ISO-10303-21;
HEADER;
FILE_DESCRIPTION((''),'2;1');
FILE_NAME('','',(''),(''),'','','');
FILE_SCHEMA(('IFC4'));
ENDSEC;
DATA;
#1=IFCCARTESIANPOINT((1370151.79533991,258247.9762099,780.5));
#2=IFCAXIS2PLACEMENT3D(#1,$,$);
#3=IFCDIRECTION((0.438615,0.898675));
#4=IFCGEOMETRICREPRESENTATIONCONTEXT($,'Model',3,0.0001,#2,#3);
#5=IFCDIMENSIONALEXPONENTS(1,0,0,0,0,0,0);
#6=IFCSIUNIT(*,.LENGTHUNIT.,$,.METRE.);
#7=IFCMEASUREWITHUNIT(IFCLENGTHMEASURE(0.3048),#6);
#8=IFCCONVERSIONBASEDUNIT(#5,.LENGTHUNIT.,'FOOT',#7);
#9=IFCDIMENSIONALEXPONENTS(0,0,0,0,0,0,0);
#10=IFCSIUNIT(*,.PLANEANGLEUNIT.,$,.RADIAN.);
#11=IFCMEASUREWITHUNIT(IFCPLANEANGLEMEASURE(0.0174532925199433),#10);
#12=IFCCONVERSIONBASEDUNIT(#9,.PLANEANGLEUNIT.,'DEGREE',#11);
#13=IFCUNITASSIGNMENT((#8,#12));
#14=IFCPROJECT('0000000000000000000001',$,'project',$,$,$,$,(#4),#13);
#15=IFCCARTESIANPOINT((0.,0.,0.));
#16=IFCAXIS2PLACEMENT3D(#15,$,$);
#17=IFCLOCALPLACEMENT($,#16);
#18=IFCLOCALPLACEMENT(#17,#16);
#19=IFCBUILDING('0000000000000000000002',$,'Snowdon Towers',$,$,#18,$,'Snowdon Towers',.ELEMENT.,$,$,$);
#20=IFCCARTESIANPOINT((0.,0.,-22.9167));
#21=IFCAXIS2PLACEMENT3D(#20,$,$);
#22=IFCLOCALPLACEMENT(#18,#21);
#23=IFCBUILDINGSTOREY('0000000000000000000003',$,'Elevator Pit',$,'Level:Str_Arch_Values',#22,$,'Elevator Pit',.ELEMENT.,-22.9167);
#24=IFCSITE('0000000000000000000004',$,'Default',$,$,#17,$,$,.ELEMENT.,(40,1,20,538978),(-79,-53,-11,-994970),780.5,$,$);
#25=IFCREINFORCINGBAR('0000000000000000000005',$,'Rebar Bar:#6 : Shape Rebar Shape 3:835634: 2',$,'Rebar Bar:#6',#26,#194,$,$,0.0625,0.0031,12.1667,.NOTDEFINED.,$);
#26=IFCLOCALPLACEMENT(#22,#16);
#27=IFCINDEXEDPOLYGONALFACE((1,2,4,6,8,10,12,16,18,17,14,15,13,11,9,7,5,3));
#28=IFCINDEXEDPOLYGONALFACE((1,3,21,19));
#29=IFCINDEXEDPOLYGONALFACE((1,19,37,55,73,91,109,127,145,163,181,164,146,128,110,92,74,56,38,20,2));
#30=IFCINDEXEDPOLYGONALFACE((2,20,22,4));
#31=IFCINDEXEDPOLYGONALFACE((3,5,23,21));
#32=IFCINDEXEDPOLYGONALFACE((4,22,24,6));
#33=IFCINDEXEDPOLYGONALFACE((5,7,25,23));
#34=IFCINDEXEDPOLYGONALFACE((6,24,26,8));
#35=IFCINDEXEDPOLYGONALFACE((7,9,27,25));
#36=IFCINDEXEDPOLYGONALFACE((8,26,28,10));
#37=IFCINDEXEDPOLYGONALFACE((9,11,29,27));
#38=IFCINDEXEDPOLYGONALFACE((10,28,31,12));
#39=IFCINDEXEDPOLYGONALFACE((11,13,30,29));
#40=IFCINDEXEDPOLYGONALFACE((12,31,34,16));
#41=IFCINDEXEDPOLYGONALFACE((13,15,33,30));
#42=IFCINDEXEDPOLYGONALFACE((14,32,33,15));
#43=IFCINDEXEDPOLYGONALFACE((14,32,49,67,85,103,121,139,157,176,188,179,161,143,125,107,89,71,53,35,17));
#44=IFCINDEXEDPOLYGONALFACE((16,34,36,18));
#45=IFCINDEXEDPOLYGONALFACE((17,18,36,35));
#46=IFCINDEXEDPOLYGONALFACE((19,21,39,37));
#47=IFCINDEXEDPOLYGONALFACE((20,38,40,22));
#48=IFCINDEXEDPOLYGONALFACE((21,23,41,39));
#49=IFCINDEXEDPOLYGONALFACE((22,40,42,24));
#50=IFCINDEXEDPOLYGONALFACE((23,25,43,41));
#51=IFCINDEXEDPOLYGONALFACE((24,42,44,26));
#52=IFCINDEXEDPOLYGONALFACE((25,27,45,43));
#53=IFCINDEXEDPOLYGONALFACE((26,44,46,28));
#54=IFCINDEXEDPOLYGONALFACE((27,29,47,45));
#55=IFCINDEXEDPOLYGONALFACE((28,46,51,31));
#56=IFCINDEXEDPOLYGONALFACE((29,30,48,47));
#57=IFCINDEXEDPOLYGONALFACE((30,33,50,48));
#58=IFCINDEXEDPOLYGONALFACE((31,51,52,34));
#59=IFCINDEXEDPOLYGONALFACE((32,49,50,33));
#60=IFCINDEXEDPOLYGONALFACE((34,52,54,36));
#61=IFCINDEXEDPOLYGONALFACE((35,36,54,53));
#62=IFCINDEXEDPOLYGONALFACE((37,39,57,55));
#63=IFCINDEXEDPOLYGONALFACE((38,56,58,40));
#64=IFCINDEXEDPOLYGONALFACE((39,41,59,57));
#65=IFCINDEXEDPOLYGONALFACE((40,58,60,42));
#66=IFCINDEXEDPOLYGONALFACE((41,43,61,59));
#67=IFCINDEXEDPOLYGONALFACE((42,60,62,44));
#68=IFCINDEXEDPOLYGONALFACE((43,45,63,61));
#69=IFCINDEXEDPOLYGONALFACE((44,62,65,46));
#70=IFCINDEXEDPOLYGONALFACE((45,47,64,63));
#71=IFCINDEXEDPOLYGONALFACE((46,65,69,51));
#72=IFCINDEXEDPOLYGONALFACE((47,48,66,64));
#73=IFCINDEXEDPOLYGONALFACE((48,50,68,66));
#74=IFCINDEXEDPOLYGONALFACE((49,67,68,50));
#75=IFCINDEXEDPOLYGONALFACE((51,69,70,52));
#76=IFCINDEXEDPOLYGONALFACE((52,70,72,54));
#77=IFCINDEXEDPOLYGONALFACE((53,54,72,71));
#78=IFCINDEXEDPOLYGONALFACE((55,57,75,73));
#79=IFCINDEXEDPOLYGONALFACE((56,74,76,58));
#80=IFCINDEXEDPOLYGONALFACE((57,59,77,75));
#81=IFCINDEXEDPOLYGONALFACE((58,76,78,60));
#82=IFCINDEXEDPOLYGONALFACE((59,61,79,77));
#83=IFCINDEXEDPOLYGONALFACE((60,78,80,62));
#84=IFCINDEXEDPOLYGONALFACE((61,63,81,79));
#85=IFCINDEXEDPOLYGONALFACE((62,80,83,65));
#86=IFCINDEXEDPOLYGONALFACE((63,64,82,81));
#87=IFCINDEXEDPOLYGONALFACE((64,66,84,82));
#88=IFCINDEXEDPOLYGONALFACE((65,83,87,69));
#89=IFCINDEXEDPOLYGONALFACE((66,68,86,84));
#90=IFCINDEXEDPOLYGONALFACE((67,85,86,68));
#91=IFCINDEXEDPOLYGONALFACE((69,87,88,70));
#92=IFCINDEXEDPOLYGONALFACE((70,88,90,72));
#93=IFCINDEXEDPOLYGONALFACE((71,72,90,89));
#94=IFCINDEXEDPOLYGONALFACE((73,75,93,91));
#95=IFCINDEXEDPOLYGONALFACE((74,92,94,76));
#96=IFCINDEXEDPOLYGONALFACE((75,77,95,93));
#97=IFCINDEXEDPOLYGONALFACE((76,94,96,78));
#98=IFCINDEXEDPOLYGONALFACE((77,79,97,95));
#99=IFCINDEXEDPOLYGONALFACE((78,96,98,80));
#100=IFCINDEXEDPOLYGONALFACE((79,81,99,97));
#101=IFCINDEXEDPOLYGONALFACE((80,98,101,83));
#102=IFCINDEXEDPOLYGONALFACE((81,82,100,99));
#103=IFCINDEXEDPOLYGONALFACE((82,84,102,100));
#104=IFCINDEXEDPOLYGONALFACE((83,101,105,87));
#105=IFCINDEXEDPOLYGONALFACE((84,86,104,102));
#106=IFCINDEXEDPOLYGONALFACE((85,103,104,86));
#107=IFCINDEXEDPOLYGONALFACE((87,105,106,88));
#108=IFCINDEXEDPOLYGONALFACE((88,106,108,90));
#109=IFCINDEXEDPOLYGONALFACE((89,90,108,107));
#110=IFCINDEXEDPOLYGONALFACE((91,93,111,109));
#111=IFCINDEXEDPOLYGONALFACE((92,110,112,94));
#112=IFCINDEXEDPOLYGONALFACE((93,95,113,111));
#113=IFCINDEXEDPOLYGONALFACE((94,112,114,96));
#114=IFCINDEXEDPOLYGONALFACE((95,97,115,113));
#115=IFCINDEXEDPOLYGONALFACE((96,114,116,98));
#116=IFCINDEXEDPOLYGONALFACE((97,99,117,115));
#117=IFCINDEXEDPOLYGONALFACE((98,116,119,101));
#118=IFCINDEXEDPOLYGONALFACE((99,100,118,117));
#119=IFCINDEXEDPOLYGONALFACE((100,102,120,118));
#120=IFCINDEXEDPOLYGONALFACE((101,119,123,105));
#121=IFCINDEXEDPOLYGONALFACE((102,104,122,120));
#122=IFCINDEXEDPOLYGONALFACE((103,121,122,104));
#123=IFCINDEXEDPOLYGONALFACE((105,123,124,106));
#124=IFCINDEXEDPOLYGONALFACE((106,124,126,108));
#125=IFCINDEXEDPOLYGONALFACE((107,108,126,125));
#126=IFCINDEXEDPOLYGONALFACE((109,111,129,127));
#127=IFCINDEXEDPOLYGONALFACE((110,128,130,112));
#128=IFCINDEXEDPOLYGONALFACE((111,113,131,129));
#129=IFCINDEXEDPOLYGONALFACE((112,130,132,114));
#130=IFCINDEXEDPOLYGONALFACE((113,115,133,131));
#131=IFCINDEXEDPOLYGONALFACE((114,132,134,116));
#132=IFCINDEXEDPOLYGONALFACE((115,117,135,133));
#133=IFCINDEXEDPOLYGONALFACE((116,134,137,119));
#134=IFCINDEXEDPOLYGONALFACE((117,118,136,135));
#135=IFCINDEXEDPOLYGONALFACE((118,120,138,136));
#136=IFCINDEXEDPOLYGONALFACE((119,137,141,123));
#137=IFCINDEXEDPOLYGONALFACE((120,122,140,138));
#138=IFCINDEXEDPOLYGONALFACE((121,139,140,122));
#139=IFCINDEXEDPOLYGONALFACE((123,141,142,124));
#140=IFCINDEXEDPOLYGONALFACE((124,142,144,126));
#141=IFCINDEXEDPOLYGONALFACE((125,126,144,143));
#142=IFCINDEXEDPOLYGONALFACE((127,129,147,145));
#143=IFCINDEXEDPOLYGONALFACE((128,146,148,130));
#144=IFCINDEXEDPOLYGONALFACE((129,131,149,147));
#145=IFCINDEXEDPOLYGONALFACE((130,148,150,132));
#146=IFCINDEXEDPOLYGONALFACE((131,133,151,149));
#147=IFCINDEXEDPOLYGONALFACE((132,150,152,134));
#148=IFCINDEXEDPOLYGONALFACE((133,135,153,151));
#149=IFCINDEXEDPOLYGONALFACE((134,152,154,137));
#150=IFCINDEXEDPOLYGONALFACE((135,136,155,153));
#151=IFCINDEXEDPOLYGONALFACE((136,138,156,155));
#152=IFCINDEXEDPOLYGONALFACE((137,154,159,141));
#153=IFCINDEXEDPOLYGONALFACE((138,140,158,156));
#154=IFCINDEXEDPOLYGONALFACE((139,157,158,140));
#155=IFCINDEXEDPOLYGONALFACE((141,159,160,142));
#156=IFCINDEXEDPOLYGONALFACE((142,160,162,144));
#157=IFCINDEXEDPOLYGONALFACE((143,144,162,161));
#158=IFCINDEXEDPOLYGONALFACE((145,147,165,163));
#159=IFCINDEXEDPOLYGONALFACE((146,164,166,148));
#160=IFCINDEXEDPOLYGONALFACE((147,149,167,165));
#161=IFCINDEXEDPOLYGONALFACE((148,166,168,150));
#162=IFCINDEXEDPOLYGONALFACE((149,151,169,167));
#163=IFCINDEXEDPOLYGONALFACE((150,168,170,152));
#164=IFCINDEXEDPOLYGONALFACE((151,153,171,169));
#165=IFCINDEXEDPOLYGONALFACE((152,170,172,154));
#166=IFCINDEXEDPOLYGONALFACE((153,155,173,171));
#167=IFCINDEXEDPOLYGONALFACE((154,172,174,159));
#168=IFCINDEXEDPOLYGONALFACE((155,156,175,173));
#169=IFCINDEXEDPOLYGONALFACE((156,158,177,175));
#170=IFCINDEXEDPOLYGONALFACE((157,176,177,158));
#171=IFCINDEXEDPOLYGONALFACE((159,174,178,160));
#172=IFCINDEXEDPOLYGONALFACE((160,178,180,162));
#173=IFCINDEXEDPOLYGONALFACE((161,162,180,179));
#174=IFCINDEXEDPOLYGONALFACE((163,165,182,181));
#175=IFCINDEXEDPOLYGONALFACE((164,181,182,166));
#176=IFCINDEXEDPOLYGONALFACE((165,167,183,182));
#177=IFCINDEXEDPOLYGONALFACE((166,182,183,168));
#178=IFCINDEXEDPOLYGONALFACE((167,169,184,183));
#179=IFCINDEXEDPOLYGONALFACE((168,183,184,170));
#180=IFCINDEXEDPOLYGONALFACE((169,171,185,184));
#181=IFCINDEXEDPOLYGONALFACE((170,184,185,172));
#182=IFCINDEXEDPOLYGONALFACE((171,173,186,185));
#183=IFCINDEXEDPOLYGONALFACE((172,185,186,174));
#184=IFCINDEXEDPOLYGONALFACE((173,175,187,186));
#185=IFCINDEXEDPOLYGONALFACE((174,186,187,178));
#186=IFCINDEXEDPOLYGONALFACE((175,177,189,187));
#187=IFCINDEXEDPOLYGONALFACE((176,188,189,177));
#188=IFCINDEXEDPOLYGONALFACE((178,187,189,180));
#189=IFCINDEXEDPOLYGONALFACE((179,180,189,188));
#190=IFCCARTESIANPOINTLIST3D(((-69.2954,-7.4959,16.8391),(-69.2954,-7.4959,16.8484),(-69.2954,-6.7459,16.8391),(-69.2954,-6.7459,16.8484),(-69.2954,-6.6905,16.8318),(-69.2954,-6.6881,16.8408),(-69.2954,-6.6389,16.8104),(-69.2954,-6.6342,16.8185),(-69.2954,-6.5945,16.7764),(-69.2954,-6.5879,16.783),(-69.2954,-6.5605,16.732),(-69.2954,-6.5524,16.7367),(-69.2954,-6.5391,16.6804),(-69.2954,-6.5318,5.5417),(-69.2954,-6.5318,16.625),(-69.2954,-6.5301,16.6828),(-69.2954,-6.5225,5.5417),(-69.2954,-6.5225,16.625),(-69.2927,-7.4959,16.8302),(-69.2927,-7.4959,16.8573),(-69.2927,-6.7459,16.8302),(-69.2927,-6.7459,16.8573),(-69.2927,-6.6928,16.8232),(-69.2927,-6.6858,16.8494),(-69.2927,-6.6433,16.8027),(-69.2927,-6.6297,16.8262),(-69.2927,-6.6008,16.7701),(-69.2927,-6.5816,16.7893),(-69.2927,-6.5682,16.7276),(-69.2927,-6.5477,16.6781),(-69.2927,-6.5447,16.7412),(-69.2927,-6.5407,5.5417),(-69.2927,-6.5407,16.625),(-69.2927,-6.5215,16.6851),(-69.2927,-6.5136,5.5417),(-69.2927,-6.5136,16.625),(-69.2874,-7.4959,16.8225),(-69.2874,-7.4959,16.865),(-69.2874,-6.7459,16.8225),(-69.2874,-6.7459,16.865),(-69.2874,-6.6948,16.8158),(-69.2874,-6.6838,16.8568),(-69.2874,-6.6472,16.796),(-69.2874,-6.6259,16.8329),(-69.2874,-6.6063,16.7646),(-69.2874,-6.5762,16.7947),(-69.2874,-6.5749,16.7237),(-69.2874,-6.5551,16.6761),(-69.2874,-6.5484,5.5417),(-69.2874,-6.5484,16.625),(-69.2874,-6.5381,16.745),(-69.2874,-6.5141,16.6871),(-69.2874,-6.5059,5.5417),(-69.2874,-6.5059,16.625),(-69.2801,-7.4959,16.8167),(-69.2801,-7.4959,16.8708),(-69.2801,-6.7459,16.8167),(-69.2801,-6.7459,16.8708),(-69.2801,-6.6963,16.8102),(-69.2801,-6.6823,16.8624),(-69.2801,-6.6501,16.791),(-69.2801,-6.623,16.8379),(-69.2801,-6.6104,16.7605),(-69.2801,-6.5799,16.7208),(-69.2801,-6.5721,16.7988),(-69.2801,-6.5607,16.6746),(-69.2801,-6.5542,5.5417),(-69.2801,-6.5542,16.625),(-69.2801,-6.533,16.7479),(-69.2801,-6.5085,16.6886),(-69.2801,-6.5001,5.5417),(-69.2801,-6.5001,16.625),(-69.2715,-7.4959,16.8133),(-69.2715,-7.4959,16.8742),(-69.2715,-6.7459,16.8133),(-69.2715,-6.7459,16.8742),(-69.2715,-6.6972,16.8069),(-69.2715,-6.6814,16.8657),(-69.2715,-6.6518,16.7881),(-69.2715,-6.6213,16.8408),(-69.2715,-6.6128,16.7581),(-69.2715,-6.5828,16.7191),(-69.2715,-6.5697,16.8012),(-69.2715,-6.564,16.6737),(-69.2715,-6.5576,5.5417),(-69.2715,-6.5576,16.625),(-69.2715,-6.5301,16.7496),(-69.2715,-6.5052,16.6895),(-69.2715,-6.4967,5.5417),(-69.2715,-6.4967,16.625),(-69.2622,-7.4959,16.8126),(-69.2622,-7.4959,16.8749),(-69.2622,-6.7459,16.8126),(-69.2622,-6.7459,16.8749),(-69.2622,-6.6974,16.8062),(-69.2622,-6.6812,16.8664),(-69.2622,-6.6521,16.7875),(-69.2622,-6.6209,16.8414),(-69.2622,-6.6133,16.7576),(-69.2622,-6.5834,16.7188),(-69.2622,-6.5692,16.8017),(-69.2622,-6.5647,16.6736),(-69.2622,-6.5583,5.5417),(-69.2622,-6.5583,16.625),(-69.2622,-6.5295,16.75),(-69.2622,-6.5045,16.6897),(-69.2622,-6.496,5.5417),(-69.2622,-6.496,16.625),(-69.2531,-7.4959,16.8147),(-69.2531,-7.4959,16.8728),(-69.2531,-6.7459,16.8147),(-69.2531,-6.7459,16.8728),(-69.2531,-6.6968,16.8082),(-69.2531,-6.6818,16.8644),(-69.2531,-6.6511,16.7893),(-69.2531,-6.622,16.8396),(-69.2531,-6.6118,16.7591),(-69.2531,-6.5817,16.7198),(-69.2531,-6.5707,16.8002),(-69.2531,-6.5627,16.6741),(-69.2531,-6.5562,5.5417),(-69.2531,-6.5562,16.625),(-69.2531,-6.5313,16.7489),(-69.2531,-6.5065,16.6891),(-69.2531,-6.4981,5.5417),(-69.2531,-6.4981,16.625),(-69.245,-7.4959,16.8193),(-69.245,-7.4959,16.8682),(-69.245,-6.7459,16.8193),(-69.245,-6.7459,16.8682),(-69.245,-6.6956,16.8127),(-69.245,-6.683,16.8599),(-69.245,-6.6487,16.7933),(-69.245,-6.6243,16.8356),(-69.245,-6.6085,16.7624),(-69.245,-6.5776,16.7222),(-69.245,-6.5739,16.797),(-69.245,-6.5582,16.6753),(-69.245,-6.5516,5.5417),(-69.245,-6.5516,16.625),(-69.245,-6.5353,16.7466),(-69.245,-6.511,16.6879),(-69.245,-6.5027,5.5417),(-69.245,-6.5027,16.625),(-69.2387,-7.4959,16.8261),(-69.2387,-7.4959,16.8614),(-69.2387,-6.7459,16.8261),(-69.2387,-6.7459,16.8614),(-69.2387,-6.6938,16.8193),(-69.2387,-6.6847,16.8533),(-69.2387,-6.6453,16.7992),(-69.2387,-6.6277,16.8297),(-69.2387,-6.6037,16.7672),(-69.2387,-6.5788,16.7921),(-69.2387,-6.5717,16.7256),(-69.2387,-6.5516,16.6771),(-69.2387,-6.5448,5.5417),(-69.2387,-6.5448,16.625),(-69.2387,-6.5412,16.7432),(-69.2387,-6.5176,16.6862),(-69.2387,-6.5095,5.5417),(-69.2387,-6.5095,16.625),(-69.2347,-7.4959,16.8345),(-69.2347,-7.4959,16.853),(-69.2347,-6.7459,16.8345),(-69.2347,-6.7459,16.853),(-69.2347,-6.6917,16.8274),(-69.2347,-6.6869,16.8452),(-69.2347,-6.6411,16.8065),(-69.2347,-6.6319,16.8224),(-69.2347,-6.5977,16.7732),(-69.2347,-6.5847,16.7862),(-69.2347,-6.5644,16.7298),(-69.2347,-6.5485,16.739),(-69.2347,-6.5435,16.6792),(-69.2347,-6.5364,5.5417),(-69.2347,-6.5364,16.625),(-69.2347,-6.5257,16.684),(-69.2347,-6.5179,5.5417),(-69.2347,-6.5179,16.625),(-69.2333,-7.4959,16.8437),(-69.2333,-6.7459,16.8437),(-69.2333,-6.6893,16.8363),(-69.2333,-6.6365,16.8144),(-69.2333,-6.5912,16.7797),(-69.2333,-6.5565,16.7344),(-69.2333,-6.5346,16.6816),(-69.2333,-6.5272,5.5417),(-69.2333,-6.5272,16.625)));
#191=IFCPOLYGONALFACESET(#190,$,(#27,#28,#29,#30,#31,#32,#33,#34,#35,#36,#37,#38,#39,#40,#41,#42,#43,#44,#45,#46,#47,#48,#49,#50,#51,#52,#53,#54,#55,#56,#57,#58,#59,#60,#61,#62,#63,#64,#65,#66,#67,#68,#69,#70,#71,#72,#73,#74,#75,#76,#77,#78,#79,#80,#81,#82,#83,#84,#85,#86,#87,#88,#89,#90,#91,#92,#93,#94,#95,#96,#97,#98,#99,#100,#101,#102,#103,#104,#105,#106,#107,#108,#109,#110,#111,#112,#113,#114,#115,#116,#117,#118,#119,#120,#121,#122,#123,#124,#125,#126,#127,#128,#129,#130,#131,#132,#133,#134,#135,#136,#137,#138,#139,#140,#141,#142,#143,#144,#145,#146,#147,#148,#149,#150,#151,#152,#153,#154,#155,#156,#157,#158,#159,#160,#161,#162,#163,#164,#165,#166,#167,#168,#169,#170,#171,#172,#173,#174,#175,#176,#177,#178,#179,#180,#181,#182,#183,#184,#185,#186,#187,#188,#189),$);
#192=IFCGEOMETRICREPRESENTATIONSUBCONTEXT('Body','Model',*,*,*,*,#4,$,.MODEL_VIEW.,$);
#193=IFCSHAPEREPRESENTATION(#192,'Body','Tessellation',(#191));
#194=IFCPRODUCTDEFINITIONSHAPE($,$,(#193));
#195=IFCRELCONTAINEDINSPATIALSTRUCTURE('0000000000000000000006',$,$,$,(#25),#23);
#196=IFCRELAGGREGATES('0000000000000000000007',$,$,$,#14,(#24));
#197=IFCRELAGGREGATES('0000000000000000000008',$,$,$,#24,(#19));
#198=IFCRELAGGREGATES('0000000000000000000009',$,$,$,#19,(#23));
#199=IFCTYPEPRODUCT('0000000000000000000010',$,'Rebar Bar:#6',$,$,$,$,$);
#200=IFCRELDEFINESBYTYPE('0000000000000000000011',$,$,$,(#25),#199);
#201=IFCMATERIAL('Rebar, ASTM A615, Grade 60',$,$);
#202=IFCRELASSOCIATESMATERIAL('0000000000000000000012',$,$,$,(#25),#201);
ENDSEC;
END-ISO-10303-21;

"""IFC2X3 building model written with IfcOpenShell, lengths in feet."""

from ifc_helpers import new_model, entity, si_unit, converted_unit, direction, frame, origin, place, context, subcontext, project, spatial, material, type_object, element, save


model = new_model("IFC2X3")

# Units and contexts
model_context = context("Model", 3, precision=0.0001, world=frame((1370151.79533991, 258247.9762099, 780.5)), true_north=direction((0.438615, 0.898675)))
body_context = subcontext(model_context, "Body", "Model", "MODEL_VIEW")
ifc_project = project(units=[converted_unit("LENGTHUNIT", "FOOT", entity("IfcLengthMeasure", 0.3048), si_unit("LENGTHUNIT", "METRE"), dimensions=[1, 0, 0, 0, 0, 0, 0]), converted_unit("PLANEANGLEUNIT", "DEGREE", entity("IfcPlaneAngleMeasure", 0.0174532925199433), si_unit("PLANEANGLEUNIT", "RADIAN"), dimensions=[0, 0, 0, 0, 0, 0, 0])], contexts=[model_context])

# Site, building, storey
site_placement = place(None, origin())
site = spatial("IfcSite", under=ifc_project, at=site_placement, Name="Default", CompositionType="ELEMENT", RefLatitude=(40, 1, 20, 538978), RefLongitude=(-79, -53, -11, -994970), RefElevation=780.5)
building_placement = place(site_placement, origin())
building = spatial("IfcBuilding", under=site, at=building_placement, Name="Snowdon Towers", LongName="Snowdon Towers", CompositionType="ELEMENT")
storey_placement = place(building_placement, frame((0.0, 0.0, -22.9167)))
storey = spatial("IfcBuildingStorey", under=building, at=storey_placement, Name="Elevator Pit", ObjectType="Level:Str_Arch_Values", LongName="Elevator Pit", CompositionType="ELEMENT", Elevation=-22.9167)

# Reinforcing bar
ifc_material_1 = material(Name="Rebar, ASTM A615, Grade 60")
type_product = type_object("IfcTypeProduct", Name="Rebar Bar:#6")
reinforcing_bar_1_placement = place(storey_placement, origin())
element("IfcReinforcingBar", 1, at=reinforcing_bar_1_placement, inside=storey, type_object=type_product, material=ifc_material_1, Name="Rebar Bar:#6 : Shape Rebar Shape 3:835634: 2", ObjectType="Rebar Bar:#6", BarLength=12.1667, BarRole="NOTDEFINED", CrossSectionArea=0.0031, NominalDiameter=0.0625, context=body_context, shape_type="AdvancedSweptSolid", body=[
    entity("IfcSweptDiskSolid", entity("IfcCompositeCurve", [entity("IfcCompositeCurveSegment", "CONTINUOUS", True, entity("IfcPolyline", [entity("IfcCartesianPoint", [-69.2645, -6.5272, 5.5417]), entity("IfcCartesianPoint", [-69.2645, -6.5272, 16.625])])), entity("IfcCompositeCurveSegment", "CONTINUOUS", True, entity("IfcTrimmedCurve", entity("IfcCircle", entity("IfcAxis2Placement3D", entity("IfcCartesianPoint", [-69.2645, -6.7459, 16.625]), entity("IfcDirection", [1.0, 0.0, 0.0]), entity("IfcDirection", [0.0, 0.0, 1.0])), 0.2188), [entity("IfcParameterValue", 270.0)], [entity("IfcParameterValue", 360.0)], True, "PARAMETER")), entity("IfcCompositeCurveSegment", "CONTINUOUS", True, entity("IfcPolyline", [entity("IfcCartesianPoint", [-69.2645, -6.7459, 16.8437]), entity("IfcCartesianPoint", [-69.2645, -7.4959, 16.8437])]))], False), 0.0312, None, 0.0, 92.0),
])

save(model, "model.ifc")
